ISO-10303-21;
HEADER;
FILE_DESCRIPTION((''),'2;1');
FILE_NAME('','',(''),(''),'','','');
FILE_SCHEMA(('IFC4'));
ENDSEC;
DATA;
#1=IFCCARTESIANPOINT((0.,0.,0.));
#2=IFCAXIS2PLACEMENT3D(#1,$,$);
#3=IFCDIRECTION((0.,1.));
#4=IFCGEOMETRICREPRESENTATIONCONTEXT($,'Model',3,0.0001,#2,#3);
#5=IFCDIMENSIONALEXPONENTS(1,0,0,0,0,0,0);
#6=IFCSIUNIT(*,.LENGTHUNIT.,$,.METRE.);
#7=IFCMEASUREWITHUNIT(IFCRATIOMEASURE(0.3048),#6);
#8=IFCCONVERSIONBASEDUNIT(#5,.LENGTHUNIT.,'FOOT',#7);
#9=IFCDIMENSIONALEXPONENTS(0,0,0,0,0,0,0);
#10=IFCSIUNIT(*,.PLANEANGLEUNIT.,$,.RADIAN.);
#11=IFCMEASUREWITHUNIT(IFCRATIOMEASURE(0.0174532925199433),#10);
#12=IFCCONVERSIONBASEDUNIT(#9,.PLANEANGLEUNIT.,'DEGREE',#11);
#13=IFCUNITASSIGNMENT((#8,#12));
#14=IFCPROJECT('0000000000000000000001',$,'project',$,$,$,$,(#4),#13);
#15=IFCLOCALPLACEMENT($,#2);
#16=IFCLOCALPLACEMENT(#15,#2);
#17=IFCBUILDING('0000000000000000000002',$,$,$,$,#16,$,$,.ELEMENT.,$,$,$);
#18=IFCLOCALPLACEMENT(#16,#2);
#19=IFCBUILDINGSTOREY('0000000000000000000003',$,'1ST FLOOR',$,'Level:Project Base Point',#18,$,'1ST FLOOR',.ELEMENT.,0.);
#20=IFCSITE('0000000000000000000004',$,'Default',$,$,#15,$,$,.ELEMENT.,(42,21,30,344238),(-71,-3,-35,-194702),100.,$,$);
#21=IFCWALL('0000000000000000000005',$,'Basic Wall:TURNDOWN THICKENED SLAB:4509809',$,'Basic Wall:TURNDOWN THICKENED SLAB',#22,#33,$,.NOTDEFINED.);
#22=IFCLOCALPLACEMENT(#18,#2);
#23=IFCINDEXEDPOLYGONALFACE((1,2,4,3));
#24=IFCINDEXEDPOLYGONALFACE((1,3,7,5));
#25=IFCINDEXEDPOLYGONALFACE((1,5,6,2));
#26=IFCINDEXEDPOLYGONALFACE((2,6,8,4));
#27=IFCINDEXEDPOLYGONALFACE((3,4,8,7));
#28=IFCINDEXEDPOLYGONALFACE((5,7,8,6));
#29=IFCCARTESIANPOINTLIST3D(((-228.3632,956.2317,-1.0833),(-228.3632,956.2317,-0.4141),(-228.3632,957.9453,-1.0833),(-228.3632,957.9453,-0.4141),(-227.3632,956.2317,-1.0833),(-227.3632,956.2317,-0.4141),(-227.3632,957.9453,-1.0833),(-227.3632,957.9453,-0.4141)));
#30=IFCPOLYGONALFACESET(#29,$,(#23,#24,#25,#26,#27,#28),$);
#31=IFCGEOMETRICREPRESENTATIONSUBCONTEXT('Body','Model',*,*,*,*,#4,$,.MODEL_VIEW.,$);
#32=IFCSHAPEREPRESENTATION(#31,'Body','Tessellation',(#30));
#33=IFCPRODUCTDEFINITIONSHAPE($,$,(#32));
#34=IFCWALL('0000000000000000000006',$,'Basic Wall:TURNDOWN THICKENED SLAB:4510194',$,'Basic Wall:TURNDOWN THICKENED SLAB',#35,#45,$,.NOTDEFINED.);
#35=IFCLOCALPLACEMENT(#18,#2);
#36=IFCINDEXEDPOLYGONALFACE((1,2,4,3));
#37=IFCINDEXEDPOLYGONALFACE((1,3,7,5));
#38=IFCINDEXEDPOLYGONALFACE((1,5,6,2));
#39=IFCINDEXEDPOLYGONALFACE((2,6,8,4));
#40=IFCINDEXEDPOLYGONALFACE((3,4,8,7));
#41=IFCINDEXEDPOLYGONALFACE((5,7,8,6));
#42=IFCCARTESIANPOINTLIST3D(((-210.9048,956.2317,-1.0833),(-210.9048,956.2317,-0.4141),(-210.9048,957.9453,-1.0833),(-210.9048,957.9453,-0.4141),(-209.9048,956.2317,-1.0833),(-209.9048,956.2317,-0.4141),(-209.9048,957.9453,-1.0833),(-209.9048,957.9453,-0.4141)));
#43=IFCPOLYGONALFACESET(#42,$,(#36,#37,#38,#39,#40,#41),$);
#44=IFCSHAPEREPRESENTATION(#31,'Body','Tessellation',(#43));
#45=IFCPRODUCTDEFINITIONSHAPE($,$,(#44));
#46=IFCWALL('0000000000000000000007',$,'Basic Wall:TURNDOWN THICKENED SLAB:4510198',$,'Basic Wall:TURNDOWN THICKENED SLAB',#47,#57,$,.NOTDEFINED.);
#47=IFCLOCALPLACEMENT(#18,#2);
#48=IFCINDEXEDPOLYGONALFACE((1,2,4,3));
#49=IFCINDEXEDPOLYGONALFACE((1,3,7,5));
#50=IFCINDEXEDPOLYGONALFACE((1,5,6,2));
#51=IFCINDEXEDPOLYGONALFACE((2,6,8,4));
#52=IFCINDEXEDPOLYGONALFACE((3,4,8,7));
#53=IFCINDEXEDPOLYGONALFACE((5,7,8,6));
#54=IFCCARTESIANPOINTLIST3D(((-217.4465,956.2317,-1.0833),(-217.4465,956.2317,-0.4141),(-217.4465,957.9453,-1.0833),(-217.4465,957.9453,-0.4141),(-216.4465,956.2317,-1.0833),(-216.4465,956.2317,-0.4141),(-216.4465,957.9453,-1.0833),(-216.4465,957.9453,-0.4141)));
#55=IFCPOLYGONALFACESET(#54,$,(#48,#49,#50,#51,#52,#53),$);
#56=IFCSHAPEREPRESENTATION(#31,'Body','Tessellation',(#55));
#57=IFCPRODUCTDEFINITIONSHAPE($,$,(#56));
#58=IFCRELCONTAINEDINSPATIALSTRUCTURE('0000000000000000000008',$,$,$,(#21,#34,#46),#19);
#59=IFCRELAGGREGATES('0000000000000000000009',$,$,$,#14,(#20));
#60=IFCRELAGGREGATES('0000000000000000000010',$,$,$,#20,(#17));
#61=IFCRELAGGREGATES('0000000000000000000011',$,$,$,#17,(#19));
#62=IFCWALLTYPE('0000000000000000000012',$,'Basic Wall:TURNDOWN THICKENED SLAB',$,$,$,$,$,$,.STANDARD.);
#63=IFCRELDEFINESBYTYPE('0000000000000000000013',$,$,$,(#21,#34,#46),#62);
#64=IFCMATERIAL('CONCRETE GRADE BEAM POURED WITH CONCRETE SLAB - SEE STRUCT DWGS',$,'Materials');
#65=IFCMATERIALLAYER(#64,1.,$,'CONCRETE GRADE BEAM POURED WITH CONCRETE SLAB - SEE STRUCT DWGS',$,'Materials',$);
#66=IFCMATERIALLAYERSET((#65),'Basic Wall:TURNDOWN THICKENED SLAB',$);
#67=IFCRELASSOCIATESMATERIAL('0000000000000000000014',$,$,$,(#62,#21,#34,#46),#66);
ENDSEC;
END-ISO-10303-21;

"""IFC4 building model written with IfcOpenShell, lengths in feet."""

from ifc_helpers import new_model, entity, si_unit, converted_unit, direction, frame, frame_2d, origin, place, context, subcontext, project, spatial, polyline, rectangle, extrude, clip, bounded_halfspace, material, layer, layer_set, layer_usage, type_object, element, save


model = new_model("IFC4")

# Units and contexts
model_context = context("Model", 3, precision=0.0001, world=origin(), true_north=direction((0.0, 1.0)))
body_context = subcontext(model_context, "Body", "Model", "MODEL_VIEW")
ifc_project = project(units=[converted_unit("LENGTHUNIT", "FOOT", entity("IfcRatioMeasure", 0.3048), si_unit("LENGTHUNIT", "METRE"), dimensions=[1, 0, 0, 0, 0, 0, 0]), converted_unit("PLANEANGLEUNIT", "DEGREE", entity("IfcRatioMeasure", 0.0174532925199433), si_unit("PLANEANGLEUNIT", "RADIAN"), dimensions=[0, 0, 0, 0, 0, 0, 0])], contexts=[model_context])

# Site, building, storey
site_placement = place(None, origin())
site = spatial("IfcSite", under=ifc_project, at=site_placement, Name="Default", CompositionType="ELEMENT", RefLatitude=(42, 21, 30, 344238), RefLongitude=(-71, -3, -35, -194702), RefElevation=100.0)
building_placement = place(site_placement, origin())
building = spatial("IfcBuilding", under=site, at=building_placement, CompositionType="ELEMENT")
storey_placement = place(building_placement, origin())
storey = spatial("IfcBuildingStorey", under=building, at=storey_placement, Name="1ST FLOOR", ObjectType="Level:Project Base Point", LongName="1ST FLOOR", CompositionType="ELEMENT", Elevation=0.0)

# Walls
ifc_material_1 = material(Name="CONCRETE GRADE BEAM POURED WITH CONCRETE SLAB - SEE STRUCT DWGS", Category="Materials")
ifc_layer_1 = layer(ifc_material_1, 1.0, Name="CONCRETE GRADE BEAM POURED WITH CONCRETE SLAB - SEE STRUCT DWGS", Category="Materials")
ifc_layer_set_1 = layer_set([ifc_layer_1], Name="Basic Wall:TURNDOWN THICKENED SLAB")
ifc_layer_usage_1 = layer_usage(ifc_layer_set_1, "AXIS2", "POSITIVE", -0.5)
wall_type_1 = type_object("IfcWallType", Name="Basic Wall:TURNDOWN THICKENED SLAB", PredefinedType="STANDARD", material=ifc_layer_set_1)
wall_1_placement = place(storey_placement, frame((-227.8632, 957.9453, -1.0833), z_axis=(0.0, 0.0, 1.0), x_axis=(0.0, -1.0, 0.0)))
element("IfcWall", 1, at=wall_1_placement, inside=storey, type_object=wall_type_1, material=ifc_layer_usage_1, Name="Basic Wall:TURNDOWN THICKENED SLAB:4509809", ObjectType="Basic Wall:TURNDOWN THICKENED SLAB", PredefinedType="NOTDEFINED", context=body_context, shape_type="Clipping", body=[
    clip(extrude(rectangle(XDim=1.7136, YDim=1.0, at=frame_2d((0.8568, 0.0), x_axis=(-1.0, 0.0))), origin(), (0.0, 0.0, 1.0), 0.6693), bounded_halfspace(frame((1.0833, -0.5, 0.6693), z_axis=(0.0, 0.0, -1.0), x_axis=(0.0, 1.0, 0.0)), True, frame((1.0833, -0.5, 0.6693), z_axis=(0.0, 0.0, -1.0), x_axis=(0.0, 1.0, 0.0)), polyline([(0.0, 0.0), (0.0, -1.0833), (1.0, -1.0833), (1.0, 0.6302), (0.0, 0.6302), (0.0, 0.0)]))),
])
ifc_layer_usage_2 = layer_usage(ifc_layer_set_1, "AXIS2", "POSITIVE", -0.5)
wall_2_placement = place(storey_placement, frame((-210.4048, 957.9453, -1.0833), z_axis=(0.0, 0.0, 1.0), x_axis=(0.0, -1.0, 0.0)))
element("IfcWall", 2, at=wall_2_placement, inside=storey, type_object=wall_type_1, material=ifc_layer_usage_2, Name="Basic Wall:TURNDOWN THICKENED SLAB:4510194", ObjectType="Basic Wall:TURNDOWN THICKENED SLAB", PredefinedType="NOTDEFINED", context=body_context, shape_type="Clipping", body=[
    clip(extrude(rectangle(XDim=1.7136, YDim=1.0, at=frame_2d((0.8568, 0.0), x_axis=(-1.0, 0.0))), origin(), (0.0, 0.0, 1.0), 0.6693), bounded_halfspace(frame((1.0833, -0.5, 0.6693), z_axis=(0.0, 0.0, -1.0), x_axis=(0.0, 1.0, 0.0)), True, frame((1.0833, -0.5, 0.6693), z_axis=(0.0, 0.0, -1.0), x_axis=(0.0, 1.0, 0.0)), polyline([(0.0, 0.0), (0.0, -1.0833), (1.0, -1.0833), (1.0, 0.6302), (0.0, 0.6302), (0.0, 0.0)]))),
])
ifc_layer_usage_3 = layer_usage(ifc_layer_set_1, "AXIS2", "NEGATIVE", 0.5)
wall_3_placement = place(storey_placement, frame((-216.9465, 957.9453, -1.0833), z_axis=(0.0, 0.0, 1.0), x_axis=(0.0, -1.0, 0.0)))
element("IfcWall", 3, at=wall_3_placement, inside=storey, type_object=wall_type_1, material=ifc_layer_usage_3, Name="Basic Wall:TURNDOWN THICKENED SLAB:4510198", ObjectType="Basic Wall:TURNDOWN THICKENED SLAB", PredefinedType="NOTDEFINED", context=body_context, shape_type="Clipping", body=[
    clip(extrude(rectangle(XDim=1.7136, YDim=1.0, at=frame_2d((0.8568, 0.0), x_axis=(-1.0, 0.0))), origin(), (0.0, 0.0, 1.0), 0.6693), bounded_halfspace(frame((0.0, -0.5, 0.6693), z_axis=(0.0, 0.0, -1.0), x_axis=(0.0, 1.0, 0.0)), True, frame((0.0, -0.5, 0.6693), z_axis=(0.0, 0.0, -1.0), x_axis=(0.0, 1.0, 0.0)), polyline([(0.0, 0.0), (1.0, 0.0), (1.0, 1.0833), (1.0, 1.7136), (0.0, 1.7136), (0.0, 0.0)]))),
])

save(model, "model.ifc")
